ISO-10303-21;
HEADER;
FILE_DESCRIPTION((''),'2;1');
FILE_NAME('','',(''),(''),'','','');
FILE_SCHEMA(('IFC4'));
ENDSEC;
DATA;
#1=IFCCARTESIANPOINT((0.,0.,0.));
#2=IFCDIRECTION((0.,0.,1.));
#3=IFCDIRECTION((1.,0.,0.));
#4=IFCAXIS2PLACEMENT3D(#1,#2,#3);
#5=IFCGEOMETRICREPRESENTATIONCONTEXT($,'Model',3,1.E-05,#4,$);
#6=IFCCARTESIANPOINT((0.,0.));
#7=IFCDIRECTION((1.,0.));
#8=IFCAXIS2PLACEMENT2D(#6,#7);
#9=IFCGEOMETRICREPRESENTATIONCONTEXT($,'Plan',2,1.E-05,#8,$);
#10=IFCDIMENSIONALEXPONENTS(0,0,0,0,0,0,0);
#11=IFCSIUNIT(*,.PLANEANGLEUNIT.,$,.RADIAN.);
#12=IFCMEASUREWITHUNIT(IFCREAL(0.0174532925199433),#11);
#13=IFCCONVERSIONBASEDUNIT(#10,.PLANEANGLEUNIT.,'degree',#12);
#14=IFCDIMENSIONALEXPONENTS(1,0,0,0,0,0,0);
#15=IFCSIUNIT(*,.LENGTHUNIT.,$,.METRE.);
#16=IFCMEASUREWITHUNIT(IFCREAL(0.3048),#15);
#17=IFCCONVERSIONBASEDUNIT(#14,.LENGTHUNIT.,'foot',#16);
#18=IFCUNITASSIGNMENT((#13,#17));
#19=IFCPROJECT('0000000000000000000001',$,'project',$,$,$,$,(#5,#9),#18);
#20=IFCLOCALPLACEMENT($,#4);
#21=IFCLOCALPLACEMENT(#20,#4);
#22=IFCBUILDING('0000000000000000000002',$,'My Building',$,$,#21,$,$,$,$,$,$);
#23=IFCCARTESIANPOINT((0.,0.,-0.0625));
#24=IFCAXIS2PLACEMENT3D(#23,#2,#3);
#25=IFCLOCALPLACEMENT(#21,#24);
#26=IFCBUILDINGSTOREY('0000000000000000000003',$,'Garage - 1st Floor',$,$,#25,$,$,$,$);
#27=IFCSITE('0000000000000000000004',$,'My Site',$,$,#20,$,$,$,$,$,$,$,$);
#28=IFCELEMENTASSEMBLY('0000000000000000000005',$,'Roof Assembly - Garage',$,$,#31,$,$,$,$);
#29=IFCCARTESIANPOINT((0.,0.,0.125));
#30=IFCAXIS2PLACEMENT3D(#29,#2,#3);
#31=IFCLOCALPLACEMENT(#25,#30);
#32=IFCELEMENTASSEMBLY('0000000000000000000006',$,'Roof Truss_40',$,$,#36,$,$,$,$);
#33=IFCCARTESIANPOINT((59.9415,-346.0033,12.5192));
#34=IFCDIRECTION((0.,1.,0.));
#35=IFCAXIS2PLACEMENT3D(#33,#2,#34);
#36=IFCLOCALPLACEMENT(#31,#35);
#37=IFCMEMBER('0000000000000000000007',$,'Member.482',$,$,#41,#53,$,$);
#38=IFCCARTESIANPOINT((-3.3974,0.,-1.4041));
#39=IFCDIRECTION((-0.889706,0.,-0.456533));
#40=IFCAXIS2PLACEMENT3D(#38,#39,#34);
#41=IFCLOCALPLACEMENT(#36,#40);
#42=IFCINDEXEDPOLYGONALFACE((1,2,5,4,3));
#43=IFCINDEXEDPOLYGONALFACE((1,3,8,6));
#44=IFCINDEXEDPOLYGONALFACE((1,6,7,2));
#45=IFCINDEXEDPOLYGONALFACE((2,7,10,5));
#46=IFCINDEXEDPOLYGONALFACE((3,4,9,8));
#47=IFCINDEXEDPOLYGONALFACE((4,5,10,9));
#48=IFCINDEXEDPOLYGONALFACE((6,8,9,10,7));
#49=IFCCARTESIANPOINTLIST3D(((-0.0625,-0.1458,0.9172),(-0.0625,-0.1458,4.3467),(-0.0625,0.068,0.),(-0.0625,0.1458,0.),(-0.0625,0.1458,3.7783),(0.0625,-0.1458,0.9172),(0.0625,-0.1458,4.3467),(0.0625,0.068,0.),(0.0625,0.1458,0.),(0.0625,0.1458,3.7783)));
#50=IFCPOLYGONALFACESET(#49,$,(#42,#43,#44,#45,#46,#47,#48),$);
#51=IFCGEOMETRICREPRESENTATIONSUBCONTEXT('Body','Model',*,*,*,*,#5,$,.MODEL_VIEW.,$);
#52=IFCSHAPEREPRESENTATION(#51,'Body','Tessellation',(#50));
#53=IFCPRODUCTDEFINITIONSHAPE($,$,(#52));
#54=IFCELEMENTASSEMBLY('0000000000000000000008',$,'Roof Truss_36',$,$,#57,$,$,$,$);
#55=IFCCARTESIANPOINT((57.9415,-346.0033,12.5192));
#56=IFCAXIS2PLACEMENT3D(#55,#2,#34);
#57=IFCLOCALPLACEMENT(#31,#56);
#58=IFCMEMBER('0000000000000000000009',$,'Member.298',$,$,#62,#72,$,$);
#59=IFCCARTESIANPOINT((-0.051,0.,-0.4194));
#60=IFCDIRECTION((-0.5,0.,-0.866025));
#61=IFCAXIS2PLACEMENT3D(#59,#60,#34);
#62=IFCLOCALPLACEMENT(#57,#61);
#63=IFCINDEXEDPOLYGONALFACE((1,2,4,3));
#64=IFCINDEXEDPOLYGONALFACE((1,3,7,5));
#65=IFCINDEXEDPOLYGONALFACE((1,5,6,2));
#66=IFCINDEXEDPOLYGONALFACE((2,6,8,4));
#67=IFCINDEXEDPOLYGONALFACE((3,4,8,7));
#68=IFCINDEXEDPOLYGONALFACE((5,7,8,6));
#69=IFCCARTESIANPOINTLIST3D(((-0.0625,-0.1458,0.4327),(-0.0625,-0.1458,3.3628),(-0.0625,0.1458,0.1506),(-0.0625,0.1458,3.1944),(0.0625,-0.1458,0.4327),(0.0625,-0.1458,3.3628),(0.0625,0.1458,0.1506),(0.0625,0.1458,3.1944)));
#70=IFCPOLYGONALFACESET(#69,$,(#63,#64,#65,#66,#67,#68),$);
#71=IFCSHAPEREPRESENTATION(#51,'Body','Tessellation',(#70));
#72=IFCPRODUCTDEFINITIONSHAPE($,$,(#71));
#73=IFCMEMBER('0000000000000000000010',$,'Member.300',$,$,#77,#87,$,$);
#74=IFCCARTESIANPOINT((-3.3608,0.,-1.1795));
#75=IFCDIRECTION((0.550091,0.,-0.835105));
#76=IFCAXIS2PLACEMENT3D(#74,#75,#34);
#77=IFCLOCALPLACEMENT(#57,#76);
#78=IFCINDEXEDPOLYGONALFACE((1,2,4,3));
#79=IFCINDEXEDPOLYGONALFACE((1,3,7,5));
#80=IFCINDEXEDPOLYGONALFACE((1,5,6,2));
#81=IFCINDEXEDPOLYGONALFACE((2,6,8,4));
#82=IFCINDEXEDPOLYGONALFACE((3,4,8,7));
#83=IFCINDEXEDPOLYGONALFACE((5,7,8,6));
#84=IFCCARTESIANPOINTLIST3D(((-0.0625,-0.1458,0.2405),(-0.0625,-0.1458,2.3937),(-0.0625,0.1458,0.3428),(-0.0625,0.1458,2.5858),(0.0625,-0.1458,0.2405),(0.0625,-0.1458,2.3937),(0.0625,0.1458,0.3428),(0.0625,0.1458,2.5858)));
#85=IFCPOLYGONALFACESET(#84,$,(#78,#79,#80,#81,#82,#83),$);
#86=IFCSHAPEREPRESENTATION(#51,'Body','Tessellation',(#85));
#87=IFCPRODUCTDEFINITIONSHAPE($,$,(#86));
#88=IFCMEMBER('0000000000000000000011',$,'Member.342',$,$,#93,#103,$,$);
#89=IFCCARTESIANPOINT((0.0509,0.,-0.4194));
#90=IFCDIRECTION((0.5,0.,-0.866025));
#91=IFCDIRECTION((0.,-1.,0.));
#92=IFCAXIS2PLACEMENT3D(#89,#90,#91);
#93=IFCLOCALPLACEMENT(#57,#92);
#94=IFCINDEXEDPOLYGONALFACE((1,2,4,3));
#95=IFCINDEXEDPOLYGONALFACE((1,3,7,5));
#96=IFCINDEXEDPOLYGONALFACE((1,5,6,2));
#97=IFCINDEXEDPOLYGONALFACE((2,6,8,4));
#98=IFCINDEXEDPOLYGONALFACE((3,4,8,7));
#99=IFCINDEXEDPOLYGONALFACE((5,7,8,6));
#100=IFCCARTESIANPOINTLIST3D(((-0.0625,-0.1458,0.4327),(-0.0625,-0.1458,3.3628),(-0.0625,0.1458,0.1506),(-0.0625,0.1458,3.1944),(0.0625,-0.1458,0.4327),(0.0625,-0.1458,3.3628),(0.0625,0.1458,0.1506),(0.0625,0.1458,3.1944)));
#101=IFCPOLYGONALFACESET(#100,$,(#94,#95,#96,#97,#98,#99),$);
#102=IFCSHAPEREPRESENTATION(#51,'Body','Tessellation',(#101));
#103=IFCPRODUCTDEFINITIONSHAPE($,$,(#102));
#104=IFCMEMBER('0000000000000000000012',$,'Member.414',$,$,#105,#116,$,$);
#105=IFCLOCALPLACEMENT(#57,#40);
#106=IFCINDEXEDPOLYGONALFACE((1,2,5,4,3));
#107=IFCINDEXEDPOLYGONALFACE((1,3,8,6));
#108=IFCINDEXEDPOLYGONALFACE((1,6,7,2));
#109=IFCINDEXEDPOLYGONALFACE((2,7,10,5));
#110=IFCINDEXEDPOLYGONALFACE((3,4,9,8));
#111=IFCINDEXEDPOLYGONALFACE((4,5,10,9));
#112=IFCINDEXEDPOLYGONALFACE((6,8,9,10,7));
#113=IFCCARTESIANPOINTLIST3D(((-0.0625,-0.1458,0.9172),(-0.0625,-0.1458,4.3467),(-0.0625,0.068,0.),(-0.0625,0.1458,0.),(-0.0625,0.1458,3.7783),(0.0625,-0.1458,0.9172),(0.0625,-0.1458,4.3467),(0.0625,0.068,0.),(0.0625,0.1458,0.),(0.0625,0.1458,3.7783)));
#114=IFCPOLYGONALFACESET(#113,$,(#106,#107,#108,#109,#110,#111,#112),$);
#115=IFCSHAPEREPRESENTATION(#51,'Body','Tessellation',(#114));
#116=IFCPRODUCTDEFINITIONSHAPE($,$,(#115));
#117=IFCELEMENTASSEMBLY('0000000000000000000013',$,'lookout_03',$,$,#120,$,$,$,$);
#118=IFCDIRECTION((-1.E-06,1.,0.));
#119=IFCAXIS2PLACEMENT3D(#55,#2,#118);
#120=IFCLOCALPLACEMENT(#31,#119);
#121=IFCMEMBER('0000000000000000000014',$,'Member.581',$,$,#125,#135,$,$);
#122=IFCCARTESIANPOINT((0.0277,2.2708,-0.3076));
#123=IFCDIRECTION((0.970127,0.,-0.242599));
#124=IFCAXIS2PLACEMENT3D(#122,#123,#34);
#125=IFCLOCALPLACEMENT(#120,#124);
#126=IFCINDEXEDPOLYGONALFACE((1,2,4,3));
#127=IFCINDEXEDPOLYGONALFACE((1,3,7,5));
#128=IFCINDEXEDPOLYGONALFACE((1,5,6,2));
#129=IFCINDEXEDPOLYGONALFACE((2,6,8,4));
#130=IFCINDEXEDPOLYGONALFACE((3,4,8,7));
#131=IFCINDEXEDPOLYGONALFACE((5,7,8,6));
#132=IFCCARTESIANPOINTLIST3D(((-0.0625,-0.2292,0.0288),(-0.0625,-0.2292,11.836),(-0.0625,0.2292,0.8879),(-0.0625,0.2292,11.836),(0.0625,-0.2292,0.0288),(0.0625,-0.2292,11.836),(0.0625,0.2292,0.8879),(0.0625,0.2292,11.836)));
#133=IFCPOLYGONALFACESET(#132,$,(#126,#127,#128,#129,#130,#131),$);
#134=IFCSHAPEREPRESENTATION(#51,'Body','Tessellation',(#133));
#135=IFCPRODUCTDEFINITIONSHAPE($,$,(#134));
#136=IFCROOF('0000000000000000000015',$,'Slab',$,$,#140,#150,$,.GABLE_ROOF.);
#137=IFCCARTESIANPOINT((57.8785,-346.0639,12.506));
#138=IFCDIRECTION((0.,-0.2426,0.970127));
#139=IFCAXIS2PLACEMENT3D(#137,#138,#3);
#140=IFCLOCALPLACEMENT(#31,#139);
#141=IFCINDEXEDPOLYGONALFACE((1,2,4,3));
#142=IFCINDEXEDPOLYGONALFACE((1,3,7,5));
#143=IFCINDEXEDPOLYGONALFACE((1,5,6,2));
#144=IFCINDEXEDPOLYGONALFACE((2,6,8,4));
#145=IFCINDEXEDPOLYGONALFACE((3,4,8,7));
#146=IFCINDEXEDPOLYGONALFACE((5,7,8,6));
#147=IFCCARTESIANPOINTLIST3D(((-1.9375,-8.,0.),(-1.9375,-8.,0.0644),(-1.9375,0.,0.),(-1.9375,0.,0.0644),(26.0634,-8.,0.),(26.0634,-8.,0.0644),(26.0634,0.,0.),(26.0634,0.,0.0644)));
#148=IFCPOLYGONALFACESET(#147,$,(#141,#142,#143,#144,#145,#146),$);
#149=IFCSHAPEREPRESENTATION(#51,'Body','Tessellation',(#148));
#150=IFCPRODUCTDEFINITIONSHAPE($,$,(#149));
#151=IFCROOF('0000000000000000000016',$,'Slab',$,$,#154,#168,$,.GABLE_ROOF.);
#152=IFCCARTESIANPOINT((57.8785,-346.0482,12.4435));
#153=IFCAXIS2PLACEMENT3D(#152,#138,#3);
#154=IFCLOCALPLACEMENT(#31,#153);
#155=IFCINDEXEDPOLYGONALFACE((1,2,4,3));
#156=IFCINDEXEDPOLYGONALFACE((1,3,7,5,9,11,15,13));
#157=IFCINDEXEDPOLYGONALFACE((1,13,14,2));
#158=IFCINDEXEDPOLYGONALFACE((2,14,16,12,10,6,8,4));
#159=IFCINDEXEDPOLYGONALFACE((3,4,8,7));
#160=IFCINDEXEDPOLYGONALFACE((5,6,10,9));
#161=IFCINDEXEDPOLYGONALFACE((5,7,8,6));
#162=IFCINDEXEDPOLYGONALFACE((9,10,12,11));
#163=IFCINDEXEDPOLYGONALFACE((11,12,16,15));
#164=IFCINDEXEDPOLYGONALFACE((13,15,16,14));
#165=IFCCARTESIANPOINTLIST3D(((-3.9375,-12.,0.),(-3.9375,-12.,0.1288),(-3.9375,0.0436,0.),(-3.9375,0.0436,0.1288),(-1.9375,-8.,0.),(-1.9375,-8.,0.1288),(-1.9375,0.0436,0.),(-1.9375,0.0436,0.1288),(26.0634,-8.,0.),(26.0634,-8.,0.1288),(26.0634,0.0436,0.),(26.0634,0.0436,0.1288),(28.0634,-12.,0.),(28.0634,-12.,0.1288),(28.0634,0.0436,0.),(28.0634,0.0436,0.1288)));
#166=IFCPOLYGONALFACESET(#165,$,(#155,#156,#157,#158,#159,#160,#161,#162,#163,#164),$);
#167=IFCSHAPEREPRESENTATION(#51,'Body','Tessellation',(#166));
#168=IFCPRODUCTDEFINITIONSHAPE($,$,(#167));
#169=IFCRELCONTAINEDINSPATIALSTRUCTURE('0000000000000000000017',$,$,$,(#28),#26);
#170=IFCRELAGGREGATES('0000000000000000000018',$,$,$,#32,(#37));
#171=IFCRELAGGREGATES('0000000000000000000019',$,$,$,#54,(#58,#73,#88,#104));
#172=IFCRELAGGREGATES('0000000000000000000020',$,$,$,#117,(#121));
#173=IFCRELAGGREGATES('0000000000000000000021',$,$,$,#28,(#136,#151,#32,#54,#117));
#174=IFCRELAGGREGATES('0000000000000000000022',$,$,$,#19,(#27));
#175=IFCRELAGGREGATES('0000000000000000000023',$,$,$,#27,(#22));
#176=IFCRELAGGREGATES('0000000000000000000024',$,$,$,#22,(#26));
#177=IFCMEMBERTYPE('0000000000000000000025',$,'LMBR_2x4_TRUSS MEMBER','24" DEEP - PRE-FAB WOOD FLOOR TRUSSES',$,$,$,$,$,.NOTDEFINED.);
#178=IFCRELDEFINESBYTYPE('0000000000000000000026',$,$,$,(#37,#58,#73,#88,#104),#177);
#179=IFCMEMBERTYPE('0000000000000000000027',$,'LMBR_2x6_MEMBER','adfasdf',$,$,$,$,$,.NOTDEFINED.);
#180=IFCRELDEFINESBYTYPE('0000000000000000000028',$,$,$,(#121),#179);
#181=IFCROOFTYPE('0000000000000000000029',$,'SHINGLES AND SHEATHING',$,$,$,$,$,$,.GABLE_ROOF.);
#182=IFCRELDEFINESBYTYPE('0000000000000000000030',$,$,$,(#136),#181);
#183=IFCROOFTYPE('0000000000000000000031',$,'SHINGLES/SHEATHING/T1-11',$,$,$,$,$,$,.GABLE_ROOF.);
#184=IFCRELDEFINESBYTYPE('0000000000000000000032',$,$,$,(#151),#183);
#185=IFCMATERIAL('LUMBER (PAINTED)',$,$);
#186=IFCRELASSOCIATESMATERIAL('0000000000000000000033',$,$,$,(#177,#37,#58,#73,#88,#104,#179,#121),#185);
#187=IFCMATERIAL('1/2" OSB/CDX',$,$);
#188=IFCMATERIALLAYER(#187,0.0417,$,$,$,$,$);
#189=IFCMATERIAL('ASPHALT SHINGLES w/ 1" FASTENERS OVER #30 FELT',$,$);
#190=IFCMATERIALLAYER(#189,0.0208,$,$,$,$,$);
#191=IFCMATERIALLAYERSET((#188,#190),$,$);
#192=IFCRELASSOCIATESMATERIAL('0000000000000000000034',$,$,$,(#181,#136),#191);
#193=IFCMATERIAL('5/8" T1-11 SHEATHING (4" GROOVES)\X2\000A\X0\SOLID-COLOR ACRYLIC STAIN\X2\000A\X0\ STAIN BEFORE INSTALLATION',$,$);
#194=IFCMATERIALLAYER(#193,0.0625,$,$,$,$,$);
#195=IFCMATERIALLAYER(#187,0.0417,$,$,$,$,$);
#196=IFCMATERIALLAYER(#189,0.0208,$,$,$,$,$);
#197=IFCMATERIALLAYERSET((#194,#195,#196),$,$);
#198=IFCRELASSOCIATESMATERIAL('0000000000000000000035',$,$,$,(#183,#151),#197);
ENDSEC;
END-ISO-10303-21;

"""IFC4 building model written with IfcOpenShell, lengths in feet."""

from ifc_helpers import new_model, entity, si_unit, converted_unit, frame, origin_with_axes, origin_2d_with_axis, place, context, subcontext, project, spatial, indexed_curve, outline, extrude, clip, halfspace, material, layer, layer_set, layer_usage, material_profile, profile_set, profile_usage, type_object, element, aggregate, save


model = new_model("IFC4")

# Units and contexts
model_context = context("Model", 3, precision=1e-05, world=origin_with_axes())
plan_context = context("Plan", 2, precision=1e-05, world=origin_2d_with_axis())
body_context = subcontext(model_context, "Body", "Model", "MODEL_VIEW")
ifc_project = project(units=[converted_unit("PLANEANGLEUNIT", "degree", entity("IfcReal", 0.0174532925199433), si_unit("PLANEANGLEUNIT", "RADIAN"), dimensions=[0, 0, 0, 0, 0, 0, 0]), converted_unit("LENGTHUNIT", "foot", entity("IfcReal", 0.3048), si_unit("LENGTHUNIT", "METRE"), dimensions=[1, 0, 0, 0, 0, 0, 0])], contexts=[model_context, plan_context])

# Site, building, storey
site_placement = place(None, origin_with_axes())
site = spatial("IfcSite", under=ifc_project, at=site_placement, Name="My Site")
building_placement = place(site_placement, origin_with_axes())
building = spatial("IfcBuilding", under=site, at=building_placement, Name="My Building")
storey_placement = place(building_placement, frame((0.0, 0.0, -0.0625), z_axis=(0.0, 0.0, 1.0), x_axis=(1.0, 0.0, 0.0)))
storey = spatial("IfcBuildingStorey", under=building, at=storey_placement, Name="Garage - 1st Floor")

# Element assemblies, members
assembly_1_placement = place(storey_placement, frame((0.0, 0.0, 0.125), z_axis=(0.0, 0.0, 1.0), x_axis=(1.0, 0.0, 0.0)))
assembly_1 = element("IfcElementAssembly", 1, at=assembly_1_placement, inside=storey, Name="Roof Assembly - Garage")
assembly_2_placement = place(assembly_1_placement, frame((59.9415, -346.0033, 12.5192), z_axis=(0.0, 0.0, 1.0), x_axis=(0.0, 1.0, 0.0)))
assembly_2 = element("IfcElementAssembly", 2, at=assembly_2_placement, Name="Roof Truss_40")
ifc_material_1 = material(Name="LUMBER (PAINTED)")
ifc_material_profile_1 = material_profile(ifc_material_1, outline(indexed_curve([(-0.0625, -0.1458), (0.0625, -0.1458), (0.0625, 0.1458), (-0.0625, 0.1458), (-0.0625, -0.1458)])))
ifc_profile_set_1 = profile_set([ifc_material_profile_1])
member_type_1 = type_object("IfcMemberType", Name="LMBR_2x4_TRUSS MEMBER", Description="24\" DEEP - PRE-FAB WOOD FLOOR TRUSSES", PredefinedType="NOTDEFINED", material=ifc_profile_set_1)
ifc_profile_usage_1 = profile_usage(ifc_profile_set_1)
member_1_placement = place(assembly_2_placement, frame((-3.3974, 0.0, -1.4041), z_axis=(-0.889706, 0.0, -0.456533), x_axis=(0.0, 1.0, 0.0)))
member_1 = element("IfcMember", 3, at=member_1_placement, type_object=member_type_1, material=ifc_profile_usage_1, Name="Member.482", context=body_context, shape_type="Clipping", body=[
    clip(clip(extrude(outline(indexed_curve([(-0.0625, -0.1458), (0.0625, -0.1458), (0.0625, 0.1458), (-0.0625, 0.1458), (-0.0625, -0.1458)])), origin_with_axes(), (0.0, 0.0, 1.0), 4.3542), halfspace(frame((0.0, 6.6441, -8.8858), z_axis=(0.0, 0.889707, 0.456533), x_axis=(1.0, 0.0, 0.0)), False)), halfspace(frame((0.0, 0.8902, -3.5265), z_axis=(-0.000001, -0.973882, -0.227053), x_axis=(-1.0, 0.000001, 0.0)), False)),
])
assembly_3_placement = place(assembly_1_placement, frame((57.9415, -346.0033, 12.5192), z_axis=(0.0, 0.0, 1.0), x_axis=(0.0, 1.0, 0.0)))
assembly_3 = element("IfcElementAssembly", 4, at=assembly_3_placement, Name="Roof Truss_36")
ifc_profile_usage_2 = profile_usage(ifc_profile_set_1)
member_2_placement = place(assembly_3_placement, frame((-0.051, 0.0, -0.4194), z_axis=(-0.5, 0.0, -0.866025), x_axis=(0.0, 1.0, 0.0)))
member_2 = element("IfcMember", 5, at=member_2_placement, type_object=member_type_1, material=ifc_profile_usage_2, Name="Member.298", context=body_context, shape_type="Clipping", body=[
    clip(clip(extrude(outline(indexed_curve([(-0.0625, -0.1458), (0.0625, -0.1458), (0.0625, 0.1458), (-0.0625, 0.1458), (-0.0625, -0.1458)])), origin_with_axes(), (0.0, 0.0, 1.0), 3.5703), halfspace(frame((0.0, 0.2544, 0.0456), z_axis=(0.0, -0.69516, -0.718855), x_axis=(-1.0, 0.000001, 0.0)), False)), halfspace(frame((0.0, 7.9951, -1.3373), z_axis=(0.0, 0.5, 0.866026), x_axis=(1.0, 0.0, 0.0)), False)),
])
ifc_profile_usage_3 = profile_usage(ifc_profile_set_1)
member_3_placement = place(assembly_3_placement, frame((-3.3608, 0.0, -1.1795), z_axis=(0.550091, 0.0, -0.835105), x_axis=(0.0, 1.0, 0.0)))
member_3 = element("IfcMember", 6, at=member_3_placement, type_object=member_type_1, material=ifc_profile_usage_3, Name="Member.300", context=body_context, shape_type="Clipping", body=[
    clip(clip(extrude(outline(indexed_curve([(-0.0625, -0.1458), (0.0625, -0.1458), (0.0625, 0.1458), (-0.0625, 0.1458), (-0.0625, -0.1458)])), origin_with_axes(), (0.0, 0.0, 1.0), 2.7815), halfspace(frame((0.0, 3.2555, 1.4338), z_axis=(0.0, 0.331063, -0.943609), x_axis=(1.0, 0.0, 0.0)), False)), halfspace(frame((0.0, 7.9609, 7.7337), z_axis=(0.0, -0.550091, 0.835105), x_axis=(-1.0, 0.0, 0.0)), False)),
])
ifc_profile_usage_4 = profile_usage(ifc_profile_set_1)
member_4_placement = place(assembly_3_placement, frame((0.0509, 0.0, -0.4194), z_axis=(0.5, 0.0, -0.866025), x_axis=(0.0, -1.0, 0.0)))
member_4 = element("IfcMember", 7, at=member_4_placement, type_object=member_type_1, material=ifc_profile_usage_4, Name="Member.342", context=body_context, shape_type="Clipping", body=[
    clip(clip(extrude(outline(indexed_curve([(-0.0625, -0.1458), (0.0625, -0.1458), (0.0625, 0.1458), (-0.0625, 0.1458), (-0.0625, -0.1458)])), origin_with_axes(), (0.0, 0.0, 1.0), 3.5703), halfspace(frame((0.0, -5.0674, 6.2043), z_axis=(0.0, 0.5, 0.866025), x_axis=(1.0, 0.0, 0.0)), False)), halfspace(frame((0.0, 0.2544, 0.0456), z_axis=(0.0, -0.695161, -0.718855), x_axis=(-1.0, 0.0, 0.0)), False)),
])
ifc_profile_usage_5 = profile_usage(ifc_profile_set_1)
member_5_placement = place(assembly_3_placement, frame((-3.3974, 0.0, -1.4041), z_axis=(-0.889706, 0.0, -0.456533), x_axis=(0.0, 1.0, 0.0)))
member_5 = element("IfcMember", 8, at=member_5_placement, type_object=member_type_1, material=ifc_profile_usage_5, Name="Member.414", context=body_context, shape_type="Clipping", body=[
    clip(clip(extrude(outline(indexed_curve([(-0.0625, -0.1458), (0.0625, -0.1458), (0.0625, 0.1458), (-0.0625, 0.1458), (-0.0625, -0.1458)])), origin_with_axes(), (0.0, 0.0, 1.0), 4.3542), halfspace(frame((0.0, 6.6441, -8.8858), z_axis=(0.0, 0.889707, 0.456533), x_axis=(1.0, 0.0, 0.0)), False)), halfspace(frame((0.0, 0.8902, -3.5265), z_axis=(-0.000001, -0.973882, -0.227053), x_axis=(-1.0, 0.000001, 0.0)), False)),
])
assembly_4_placement = place(assembly_1_placement, frame((57.9415, -346.0033, 12.5192), z_axis=(0.0, 0.0, 1.0), x_axis=(-0.000001, 1.0, 0.0)))
assembly_4 = element("IfcElementAssembly", 9, at=assembly_4_placement, Name="lookout_03")
ifc_material_profile_2 = material_profile(ifc_material_1, outline(indexed_curve([(-0.0625, 0.2292), (0.0625, 0.2292), (0.0625, -0.2292), (-0.0625, -0.2292), (-0.0625, 0.2292)])))
ifc_profile_set_2 = profile_set([ifc_material_profile_2])
ifc_profile_usage_6 = profile_usage(ifc_profile_set_2)
member_type_2 = type_object("IfcMemberType", Name="LMBR_2x6_MEMBER", Description="adfasdf", PredefinedType="NOTDEFINED", material=ifc_profile_set_2)
member_6_placement = place(assembly_4_placement, frame((0.0277, 2.2708, -0.3076), z_axis=(0.970127, 0.0, -0.242599), x_axis=(0.0, 1.0, 0.0)))
member_6 = element("IfcMember", 10, at=member_6_placement, type_object=member_type_2, material=ifc_profile_usage_6, Name="Member.581", context=body_context, shape_type="Clipping", body=[
    clip(extrude(outline(indexed_curve([(-0.0625, 0.2292), (0.0625, 0.2292), (0.0625, -0.2292), (-0.0625, -0.2292), (-0.0625, 0.2292)])), origin_with_axes(), (0.0, 0.0, 1.0), 11.836), halfspace(frame((0.0, 0.2427, 0.9133), z_axis=(0.0, 0.882291, -0.470704), x_axis=(1.0, 0.0, 0.0)), False)),
])
aggregate(assembly_2, [member_1])
aggregate(assembly_3, [member_2, member_3, member_4, member_5])
aggregate(assembly_4, [member_6])

# Roofs
ifc_material_2 = material(Name="1/2\" OSB/CDX")
ifc_layer_1 = layer(ifc_material_2, 0.0417)
ifc_material_3 = material(Name="ASPHALT SHINGLES w/ 1\" FASTENERS OVER #30 FELT")
ifc_layer_2 = layer(ifc_material_3, 0.0208)
ifc_layer_set_1 = layer_set([ifc_layer_1, ifc_layer_2])
ifc_layer_usage_1 = layer_usage(ifc_layer_set_1, "AXIS3", "POSITIVE", 0.0)
roof_type_1 = type_object("IfcRoofType", Name="SHINGLES AND SHEATHING", PredefinedType="GABLE_ROOF", material=ifc_layer_set_1)
roof_1_placement = place(assembly_1_placement, frame((57.8785, -346.0639, 12.506), z_axis=(0.0, -0.2426, 0.970127), x_axis=(1.0, 0.0, 0.0)))
roof_1 = element("IfcRoof", 11, at=roof_1_placement, type_object=roof_type_1, material=ifc_layer_usage_1, Name="Slab", PredefinedType="GABLE_ROOF", context=body_context, shape_type="SweptSolid", body=[
    extrude(outline(indexed_curve([(26.0634, 0.0), (26.0634, -8.0), (-1.9375, -8.0), (-1.9375, 0.0), (26.0634, 0.0)])), None, (0.0, 0.0, 1.0), 0.0644),
])
ifc_material_4 = material(Name="5/8\" T1-11 SHEATHING (4\" GROOVES)\nSOLID-COLOR ACRYLIC STAIN\n STAIN BEFORE INSTALLATION")
ifc_layer_3 = layer(ifc_material_4, 0.0625)
ifc_layer_4 = layer(ifc_material_2, 0.0417)
ifc_layer_5 = layer(ifc_material_3, 0.0208)
ifc_layer_set_2 = layer_set([ifc_layer_3, ifc_layer_4, ifc_layer_5])
ifc_layer_usage_2 = layer_usage(ifc_layer_set_2, "AXIS3", "POSITIVE", 0.0)
roof_type_2 = type_object("IfcRoofType", Name="SHINGLES/SHEATHING/T1-11", PredefinedType="GABLE_ROOF", material=ifc_layer_set_2)
roof_2_placement = place(assembly_1_placement, frame((57.8785, -346.0482, 12.4435), z_axis=(0.0, -0.2426, 0.970127), x_axis=(1.0, 0.0, 0.0)))
roof_2 = element("IfcRoof", 12, at=roof_2_placement, type_object=roof_type_2, material=ifc_layer_usage_2, Name="Slab", PredefinedType="GABLE_ROOF", context=body_context, shape_type="SweptSolid", body=[
    extrude(outline(indexed_curve([(28.0634, -12.0), (-3.9375, -12.0), (-3.9375, 0.0436), (-1.9375, 0.0436), (-1.9375, -8.0), (26.0634, -8.0), (26.0634, 0.0436), (28.0634, 0.0436), (28.0634, -12.0)])), None, (0.0, 0.0, 1.0), 0.1288),
])
aggregate(assembly_1, [roof_1, roof_2, assembly_2, assembly_3, assembly_4])

save(model, "model.ifc")
